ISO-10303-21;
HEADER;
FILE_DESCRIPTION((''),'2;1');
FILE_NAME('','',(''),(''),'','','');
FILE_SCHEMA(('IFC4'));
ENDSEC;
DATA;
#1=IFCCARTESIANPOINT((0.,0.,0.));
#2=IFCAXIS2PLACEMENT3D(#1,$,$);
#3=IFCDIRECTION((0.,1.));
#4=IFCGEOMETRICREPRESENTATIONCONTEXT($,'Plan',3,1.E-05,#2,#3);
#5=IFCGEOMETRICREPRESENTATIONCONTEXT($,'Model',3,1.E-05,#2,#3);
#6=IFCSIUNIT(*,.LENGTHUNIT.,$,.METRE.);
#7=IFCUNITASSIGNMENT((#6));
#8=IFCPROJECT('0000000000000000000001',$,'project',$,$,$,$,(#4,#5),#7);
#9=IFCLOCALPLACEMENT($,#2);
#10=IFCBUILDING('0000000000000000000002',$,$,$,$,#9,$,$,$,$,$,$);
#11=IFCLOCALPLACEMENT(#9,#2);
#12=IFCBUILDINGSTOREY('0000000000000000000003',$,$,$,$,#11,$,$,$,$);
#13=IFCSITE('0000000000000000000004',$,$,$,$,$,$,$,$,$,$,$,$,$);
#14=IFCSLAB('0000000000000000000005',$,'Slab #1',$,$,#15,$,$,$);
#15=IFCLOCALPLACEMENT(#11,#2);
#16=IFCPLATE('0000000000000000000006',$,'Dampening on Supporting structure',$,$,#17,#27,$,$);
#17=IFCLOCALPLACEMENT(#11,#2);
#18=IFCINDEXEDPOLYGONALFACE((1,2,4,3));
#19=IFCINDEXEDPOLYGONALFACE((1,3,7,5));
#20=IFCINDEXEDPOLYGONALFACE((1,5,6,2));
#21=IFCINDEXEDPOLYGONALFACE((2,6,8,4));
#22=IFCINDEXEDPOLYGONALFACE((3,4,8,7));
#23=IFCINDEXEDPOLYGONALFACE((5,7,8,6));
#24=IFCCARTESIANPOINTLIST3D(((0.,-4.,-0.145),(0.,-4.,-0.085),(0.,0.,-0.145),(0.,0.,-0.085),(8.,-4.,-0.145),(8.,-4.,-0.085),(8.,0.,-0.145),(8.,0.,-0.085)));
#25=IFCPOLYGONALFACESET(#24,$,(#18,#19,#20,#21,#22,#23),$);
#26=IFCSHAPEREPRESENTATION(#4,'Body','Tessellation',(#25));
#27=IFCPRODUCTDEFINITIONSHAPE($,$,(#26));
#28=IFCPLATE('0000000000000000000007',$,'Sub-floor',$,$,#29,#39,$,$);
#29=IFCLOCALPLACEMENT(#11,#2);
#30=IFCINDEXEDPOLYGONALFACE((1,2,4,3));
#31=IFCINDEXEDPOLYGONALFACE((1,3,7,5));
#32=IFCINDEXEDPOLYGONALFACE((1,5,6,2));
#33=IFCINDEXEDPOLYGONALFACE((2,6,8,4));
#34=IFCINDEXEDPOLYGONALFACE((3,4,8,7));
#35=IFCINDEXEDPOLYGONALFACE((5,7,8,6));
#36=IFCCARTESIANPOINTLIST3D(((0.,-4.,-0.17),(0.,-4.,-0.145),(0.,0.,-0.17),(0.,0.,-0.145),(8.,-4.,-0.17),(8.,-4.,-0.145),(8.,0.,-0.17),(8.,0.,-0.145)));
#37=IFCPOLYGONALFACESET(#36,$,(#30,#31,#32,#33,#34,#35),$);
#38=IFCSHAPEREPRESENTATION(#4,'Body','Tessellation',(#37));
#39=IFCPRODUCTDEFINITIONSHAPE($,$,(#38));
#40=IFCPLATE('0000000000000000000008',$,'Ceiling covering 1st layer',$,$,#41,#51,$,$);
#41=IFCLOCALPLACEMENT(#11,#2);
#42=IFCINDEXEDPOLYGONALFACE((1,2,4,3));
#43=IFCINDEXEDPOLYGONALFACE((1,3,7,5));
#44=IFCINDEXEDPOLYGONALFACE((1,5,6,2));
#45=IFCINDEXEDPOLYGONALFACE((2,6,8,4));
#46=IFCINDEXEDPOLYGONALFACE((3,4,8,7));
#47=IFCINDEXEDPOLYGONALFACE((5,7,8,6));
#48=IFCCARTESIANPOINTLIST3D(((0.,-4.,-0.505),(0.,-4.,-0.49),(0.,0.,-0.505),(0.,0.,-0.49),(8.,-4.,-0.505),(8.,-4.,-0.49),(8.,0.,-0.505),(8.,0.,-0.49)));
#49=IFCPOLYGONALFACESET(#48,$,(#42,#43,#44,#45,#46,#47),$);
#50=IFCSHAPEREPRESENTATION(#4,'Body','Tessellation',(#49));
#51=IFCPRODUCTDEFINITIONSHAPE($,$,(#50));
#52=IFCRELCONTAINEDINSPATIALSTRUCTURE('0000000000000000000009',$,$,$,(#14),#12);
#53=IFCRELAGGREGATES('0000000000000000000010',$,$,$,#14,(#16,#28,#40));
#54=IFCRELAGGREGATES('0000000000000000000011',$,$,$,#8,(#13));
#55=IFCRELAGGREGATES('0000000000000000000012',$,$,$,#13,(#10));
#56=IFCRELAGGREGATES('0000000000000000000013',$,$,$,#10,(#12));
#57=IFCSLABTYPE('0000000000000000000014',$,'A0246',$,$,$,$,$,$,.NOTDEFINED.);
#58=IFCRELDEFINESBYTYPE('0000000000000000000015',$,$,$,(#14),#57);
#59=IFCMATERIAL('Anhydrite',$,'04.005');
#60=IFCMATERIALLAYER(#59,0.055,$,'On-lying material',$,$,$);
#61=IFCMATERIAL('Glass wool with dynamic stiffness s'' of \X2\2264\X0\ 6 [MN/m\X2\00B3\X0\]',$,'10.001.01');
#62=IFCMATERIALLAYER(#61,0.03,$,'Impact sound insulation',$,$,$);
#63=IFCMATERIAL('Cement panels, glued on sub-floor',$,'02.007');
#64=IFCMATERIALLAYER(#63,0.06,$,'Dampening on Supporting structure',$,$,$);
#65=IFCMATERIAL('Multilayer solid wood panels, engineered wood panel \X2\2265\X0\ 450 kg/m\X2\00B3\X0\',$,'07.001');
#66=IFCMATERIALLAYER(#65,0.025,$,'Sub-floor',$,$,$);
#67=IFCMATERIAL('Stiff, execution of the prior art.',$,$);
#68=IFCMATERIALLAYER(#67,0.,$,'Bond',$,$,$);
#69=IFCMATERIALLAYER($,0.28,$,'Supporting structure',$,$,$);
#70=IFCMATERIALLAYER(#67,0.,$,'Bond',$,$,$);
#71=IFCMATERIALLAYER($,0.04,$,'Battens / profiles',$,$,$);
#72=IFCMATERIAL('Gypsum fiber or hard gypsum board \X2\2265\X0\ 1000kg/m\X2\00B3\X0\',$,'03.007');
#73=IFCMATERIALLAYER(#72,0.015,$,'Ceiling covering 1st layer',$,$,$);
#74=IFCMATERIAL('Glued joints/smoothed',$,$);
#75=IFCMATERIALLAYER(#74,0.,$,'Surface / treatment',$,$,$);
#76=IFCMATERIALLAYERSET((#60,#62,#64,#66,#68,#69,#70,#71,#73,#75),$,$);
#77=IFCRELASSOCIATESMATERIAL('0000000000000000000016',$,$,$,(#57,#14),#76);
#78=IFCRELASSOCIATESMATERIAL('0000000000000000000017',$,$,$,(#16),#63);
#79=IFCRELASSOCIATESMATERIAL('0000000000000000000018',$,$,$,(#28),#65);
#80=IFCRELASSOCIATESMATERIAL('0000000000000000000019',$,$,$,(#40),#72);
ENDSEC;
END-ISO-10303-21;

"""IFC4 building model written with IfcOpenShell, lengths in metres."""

from ifc_helpers import new_model, si_unit, direction, frame, frame_2d, origin, place, context, project, spatial, rectangle, extrude, material, layer, layer_set, type_object, element, aggregate, save


model = new_model("IFC4")

# Units and contexts
plan_context = context("Plan", 3, precision=1e-05, world=origin(), true_north=direction((0.0, 1.0)))
model_context = context("Model", 3, precision=1e-05, world=origin(), true_north=direction((0.0, 1.0)))
ifc_project = project(units=[si_unit("LENGTHUNIT", "METRE")], contexts=[plan_context, model_context])

# Site, building, storey
site = spatial("IfcSite", under=ifc_project)
building_placement = place(None, origin())
building = spatial("IfcBuilding", under=site, at=building_placement)
storey_placement = place(building_placement, origin())
storey = spatial("IfcBuildingStorey", under=building, at=storey_placement)

# Slab, plates
ifc_material_1 = material(Name="Anhydrite", Category="04.005")
ifc_layer_1 = layer(ifc_material_1, 0.055, Name="On-lying material")
ifc_material_2 = material(Name="Glass wool with dynamic stiffness s' of ≤ 6 [MN/m³]", Category="10.001.01")
ifc_layer_2 = layer(ifc_material_2, 0.03, Name="Impact sound insulation")
ifc_material_3 = material(Name="Cement panels, glued on sub-floor", Category="02.007")
ifc_layer_3 = layer(ifc_material_3, 0.06, Name="Dampening on Supporting structure")
ifc_material_4 = material(Name="Multilayer solid wood panels, engineered wood panel ≥ 450 kg/m³", Category="07.001")
ifc_layer_4 = layer(ifc_material_4, 0.025, Name="Sub-floor")
ifc_material_5 = material(Name="Stiff, execution of the prior art.")
ifc_layer_5 = layer(ifc_material_5, 0.0, Name="Bond")
ifc_layer_6 = layer(None, 0.28, Name="Supporting structure")
ifc_layer_7 = layer(ifc_material_5, 0.0, Name="Bond")
ifc_layer_8 = layer(None, 0.04, Name="Battens / profiles")
ifc_material_6 = material(Name="Gypsum fiber or hard gypsum board ≥ 1000kg/m³", Category="03.007")
ifc_layer_9 = layer(ifc_material_6, 0.015, Name="Ceiling covering 1st layer")
ifc_material_7 = material(Name="Glued joints/smoothed")
ifc_layer_10 = layer(ifc_material_7, 0.0, Name="Surface / treatment")
ifc_layer_set = layer_set([ifc_layer_1, ifc_layer_2, ifc_layer_3, ifc_layer_4, ifc_layer_5, ifc_layer_6, ifc_layer_7, ifc_layer_8, ifc_layer_9, ifc_layer_10])
slab_type = type_object("IfcSlabType", Name="A0246", PredefinedType="NOTDEFINED", material=ifc_layer_set)
slab_placement = place(None, frame((0.0, 0.0, 0.0), z_axis=(0.0, 0.0, -1.0), x_axis=(1.0, 0.0, 0.0)))
slab = element("IfcSlab", 1, at=slab_placement, inside=storey, type_object=slab_type, material=ifc_layer_set, Name="Slab #1")
plate_1_placement = place(slab_placement, origin())
plate_1 = element("IfcPlate", 2, at=plate_1_placement, material=ifc_material_3, Name="Dampening on Supporting structure", context=plan_context, shape_type="SweptSolid", body=[
    extrude(rectangle(XDim=8.0, YDim=4.0, at=frame_2d((4.0, 2.0), x_axis=(1.0, 0.0))), frame((0.0, 0.0, 0.085), z_axis=(0.0, 0.0, 1.0), x_axis=(1.0, 0.0, 0.0)), (0.0, 0.0, 1.0), 0.06),
])
plate_2_placement = place(slab_placement, origin())
plate_2 = element("IfcPlate", 3, at=plate_2_placement, material=ifc_material_4, Name="Sub-floor", context=plan_context, shape_type="SweptSolid", body=[
    extrude(rectangle(XDim=8.0, YDim=4.0, at=frame_2d((4.0, 2.0), x_axis=(1.0, 0.0))), frame((0.0, 0.0, 0.145), z_axis=(0.0, 0.0, 1.0), x_axis=(1.0, 0.0, 0.0)), (0.0, 0.0, 1.0), 0.025),
])
plate_3_placement = place(slab_placement, origin())
plate_3 = element("IfcPlate", 4, at=plate_3_placement, material=ifc_material_6, Name="Ceiling covering 1st layer", context=plan_context, shape_type="SweptSolid", body=[
    extrude(rectangle(XDim=8.0, YDim=4.0, at=frame_2d((4.0, 2.0), x_axis=(1.0, 0.0))), frame((0.0, 0.0, 0.49), z_axis=(0.0, 0.0, 1.0), x_axis=(1.0, 0.0, 0.0)), (0.0, 0.0, 1.0), 0.015),
])
aggregate(slab, [plate_1, plate_2, plate_3])

save(model, "model.ifc")
